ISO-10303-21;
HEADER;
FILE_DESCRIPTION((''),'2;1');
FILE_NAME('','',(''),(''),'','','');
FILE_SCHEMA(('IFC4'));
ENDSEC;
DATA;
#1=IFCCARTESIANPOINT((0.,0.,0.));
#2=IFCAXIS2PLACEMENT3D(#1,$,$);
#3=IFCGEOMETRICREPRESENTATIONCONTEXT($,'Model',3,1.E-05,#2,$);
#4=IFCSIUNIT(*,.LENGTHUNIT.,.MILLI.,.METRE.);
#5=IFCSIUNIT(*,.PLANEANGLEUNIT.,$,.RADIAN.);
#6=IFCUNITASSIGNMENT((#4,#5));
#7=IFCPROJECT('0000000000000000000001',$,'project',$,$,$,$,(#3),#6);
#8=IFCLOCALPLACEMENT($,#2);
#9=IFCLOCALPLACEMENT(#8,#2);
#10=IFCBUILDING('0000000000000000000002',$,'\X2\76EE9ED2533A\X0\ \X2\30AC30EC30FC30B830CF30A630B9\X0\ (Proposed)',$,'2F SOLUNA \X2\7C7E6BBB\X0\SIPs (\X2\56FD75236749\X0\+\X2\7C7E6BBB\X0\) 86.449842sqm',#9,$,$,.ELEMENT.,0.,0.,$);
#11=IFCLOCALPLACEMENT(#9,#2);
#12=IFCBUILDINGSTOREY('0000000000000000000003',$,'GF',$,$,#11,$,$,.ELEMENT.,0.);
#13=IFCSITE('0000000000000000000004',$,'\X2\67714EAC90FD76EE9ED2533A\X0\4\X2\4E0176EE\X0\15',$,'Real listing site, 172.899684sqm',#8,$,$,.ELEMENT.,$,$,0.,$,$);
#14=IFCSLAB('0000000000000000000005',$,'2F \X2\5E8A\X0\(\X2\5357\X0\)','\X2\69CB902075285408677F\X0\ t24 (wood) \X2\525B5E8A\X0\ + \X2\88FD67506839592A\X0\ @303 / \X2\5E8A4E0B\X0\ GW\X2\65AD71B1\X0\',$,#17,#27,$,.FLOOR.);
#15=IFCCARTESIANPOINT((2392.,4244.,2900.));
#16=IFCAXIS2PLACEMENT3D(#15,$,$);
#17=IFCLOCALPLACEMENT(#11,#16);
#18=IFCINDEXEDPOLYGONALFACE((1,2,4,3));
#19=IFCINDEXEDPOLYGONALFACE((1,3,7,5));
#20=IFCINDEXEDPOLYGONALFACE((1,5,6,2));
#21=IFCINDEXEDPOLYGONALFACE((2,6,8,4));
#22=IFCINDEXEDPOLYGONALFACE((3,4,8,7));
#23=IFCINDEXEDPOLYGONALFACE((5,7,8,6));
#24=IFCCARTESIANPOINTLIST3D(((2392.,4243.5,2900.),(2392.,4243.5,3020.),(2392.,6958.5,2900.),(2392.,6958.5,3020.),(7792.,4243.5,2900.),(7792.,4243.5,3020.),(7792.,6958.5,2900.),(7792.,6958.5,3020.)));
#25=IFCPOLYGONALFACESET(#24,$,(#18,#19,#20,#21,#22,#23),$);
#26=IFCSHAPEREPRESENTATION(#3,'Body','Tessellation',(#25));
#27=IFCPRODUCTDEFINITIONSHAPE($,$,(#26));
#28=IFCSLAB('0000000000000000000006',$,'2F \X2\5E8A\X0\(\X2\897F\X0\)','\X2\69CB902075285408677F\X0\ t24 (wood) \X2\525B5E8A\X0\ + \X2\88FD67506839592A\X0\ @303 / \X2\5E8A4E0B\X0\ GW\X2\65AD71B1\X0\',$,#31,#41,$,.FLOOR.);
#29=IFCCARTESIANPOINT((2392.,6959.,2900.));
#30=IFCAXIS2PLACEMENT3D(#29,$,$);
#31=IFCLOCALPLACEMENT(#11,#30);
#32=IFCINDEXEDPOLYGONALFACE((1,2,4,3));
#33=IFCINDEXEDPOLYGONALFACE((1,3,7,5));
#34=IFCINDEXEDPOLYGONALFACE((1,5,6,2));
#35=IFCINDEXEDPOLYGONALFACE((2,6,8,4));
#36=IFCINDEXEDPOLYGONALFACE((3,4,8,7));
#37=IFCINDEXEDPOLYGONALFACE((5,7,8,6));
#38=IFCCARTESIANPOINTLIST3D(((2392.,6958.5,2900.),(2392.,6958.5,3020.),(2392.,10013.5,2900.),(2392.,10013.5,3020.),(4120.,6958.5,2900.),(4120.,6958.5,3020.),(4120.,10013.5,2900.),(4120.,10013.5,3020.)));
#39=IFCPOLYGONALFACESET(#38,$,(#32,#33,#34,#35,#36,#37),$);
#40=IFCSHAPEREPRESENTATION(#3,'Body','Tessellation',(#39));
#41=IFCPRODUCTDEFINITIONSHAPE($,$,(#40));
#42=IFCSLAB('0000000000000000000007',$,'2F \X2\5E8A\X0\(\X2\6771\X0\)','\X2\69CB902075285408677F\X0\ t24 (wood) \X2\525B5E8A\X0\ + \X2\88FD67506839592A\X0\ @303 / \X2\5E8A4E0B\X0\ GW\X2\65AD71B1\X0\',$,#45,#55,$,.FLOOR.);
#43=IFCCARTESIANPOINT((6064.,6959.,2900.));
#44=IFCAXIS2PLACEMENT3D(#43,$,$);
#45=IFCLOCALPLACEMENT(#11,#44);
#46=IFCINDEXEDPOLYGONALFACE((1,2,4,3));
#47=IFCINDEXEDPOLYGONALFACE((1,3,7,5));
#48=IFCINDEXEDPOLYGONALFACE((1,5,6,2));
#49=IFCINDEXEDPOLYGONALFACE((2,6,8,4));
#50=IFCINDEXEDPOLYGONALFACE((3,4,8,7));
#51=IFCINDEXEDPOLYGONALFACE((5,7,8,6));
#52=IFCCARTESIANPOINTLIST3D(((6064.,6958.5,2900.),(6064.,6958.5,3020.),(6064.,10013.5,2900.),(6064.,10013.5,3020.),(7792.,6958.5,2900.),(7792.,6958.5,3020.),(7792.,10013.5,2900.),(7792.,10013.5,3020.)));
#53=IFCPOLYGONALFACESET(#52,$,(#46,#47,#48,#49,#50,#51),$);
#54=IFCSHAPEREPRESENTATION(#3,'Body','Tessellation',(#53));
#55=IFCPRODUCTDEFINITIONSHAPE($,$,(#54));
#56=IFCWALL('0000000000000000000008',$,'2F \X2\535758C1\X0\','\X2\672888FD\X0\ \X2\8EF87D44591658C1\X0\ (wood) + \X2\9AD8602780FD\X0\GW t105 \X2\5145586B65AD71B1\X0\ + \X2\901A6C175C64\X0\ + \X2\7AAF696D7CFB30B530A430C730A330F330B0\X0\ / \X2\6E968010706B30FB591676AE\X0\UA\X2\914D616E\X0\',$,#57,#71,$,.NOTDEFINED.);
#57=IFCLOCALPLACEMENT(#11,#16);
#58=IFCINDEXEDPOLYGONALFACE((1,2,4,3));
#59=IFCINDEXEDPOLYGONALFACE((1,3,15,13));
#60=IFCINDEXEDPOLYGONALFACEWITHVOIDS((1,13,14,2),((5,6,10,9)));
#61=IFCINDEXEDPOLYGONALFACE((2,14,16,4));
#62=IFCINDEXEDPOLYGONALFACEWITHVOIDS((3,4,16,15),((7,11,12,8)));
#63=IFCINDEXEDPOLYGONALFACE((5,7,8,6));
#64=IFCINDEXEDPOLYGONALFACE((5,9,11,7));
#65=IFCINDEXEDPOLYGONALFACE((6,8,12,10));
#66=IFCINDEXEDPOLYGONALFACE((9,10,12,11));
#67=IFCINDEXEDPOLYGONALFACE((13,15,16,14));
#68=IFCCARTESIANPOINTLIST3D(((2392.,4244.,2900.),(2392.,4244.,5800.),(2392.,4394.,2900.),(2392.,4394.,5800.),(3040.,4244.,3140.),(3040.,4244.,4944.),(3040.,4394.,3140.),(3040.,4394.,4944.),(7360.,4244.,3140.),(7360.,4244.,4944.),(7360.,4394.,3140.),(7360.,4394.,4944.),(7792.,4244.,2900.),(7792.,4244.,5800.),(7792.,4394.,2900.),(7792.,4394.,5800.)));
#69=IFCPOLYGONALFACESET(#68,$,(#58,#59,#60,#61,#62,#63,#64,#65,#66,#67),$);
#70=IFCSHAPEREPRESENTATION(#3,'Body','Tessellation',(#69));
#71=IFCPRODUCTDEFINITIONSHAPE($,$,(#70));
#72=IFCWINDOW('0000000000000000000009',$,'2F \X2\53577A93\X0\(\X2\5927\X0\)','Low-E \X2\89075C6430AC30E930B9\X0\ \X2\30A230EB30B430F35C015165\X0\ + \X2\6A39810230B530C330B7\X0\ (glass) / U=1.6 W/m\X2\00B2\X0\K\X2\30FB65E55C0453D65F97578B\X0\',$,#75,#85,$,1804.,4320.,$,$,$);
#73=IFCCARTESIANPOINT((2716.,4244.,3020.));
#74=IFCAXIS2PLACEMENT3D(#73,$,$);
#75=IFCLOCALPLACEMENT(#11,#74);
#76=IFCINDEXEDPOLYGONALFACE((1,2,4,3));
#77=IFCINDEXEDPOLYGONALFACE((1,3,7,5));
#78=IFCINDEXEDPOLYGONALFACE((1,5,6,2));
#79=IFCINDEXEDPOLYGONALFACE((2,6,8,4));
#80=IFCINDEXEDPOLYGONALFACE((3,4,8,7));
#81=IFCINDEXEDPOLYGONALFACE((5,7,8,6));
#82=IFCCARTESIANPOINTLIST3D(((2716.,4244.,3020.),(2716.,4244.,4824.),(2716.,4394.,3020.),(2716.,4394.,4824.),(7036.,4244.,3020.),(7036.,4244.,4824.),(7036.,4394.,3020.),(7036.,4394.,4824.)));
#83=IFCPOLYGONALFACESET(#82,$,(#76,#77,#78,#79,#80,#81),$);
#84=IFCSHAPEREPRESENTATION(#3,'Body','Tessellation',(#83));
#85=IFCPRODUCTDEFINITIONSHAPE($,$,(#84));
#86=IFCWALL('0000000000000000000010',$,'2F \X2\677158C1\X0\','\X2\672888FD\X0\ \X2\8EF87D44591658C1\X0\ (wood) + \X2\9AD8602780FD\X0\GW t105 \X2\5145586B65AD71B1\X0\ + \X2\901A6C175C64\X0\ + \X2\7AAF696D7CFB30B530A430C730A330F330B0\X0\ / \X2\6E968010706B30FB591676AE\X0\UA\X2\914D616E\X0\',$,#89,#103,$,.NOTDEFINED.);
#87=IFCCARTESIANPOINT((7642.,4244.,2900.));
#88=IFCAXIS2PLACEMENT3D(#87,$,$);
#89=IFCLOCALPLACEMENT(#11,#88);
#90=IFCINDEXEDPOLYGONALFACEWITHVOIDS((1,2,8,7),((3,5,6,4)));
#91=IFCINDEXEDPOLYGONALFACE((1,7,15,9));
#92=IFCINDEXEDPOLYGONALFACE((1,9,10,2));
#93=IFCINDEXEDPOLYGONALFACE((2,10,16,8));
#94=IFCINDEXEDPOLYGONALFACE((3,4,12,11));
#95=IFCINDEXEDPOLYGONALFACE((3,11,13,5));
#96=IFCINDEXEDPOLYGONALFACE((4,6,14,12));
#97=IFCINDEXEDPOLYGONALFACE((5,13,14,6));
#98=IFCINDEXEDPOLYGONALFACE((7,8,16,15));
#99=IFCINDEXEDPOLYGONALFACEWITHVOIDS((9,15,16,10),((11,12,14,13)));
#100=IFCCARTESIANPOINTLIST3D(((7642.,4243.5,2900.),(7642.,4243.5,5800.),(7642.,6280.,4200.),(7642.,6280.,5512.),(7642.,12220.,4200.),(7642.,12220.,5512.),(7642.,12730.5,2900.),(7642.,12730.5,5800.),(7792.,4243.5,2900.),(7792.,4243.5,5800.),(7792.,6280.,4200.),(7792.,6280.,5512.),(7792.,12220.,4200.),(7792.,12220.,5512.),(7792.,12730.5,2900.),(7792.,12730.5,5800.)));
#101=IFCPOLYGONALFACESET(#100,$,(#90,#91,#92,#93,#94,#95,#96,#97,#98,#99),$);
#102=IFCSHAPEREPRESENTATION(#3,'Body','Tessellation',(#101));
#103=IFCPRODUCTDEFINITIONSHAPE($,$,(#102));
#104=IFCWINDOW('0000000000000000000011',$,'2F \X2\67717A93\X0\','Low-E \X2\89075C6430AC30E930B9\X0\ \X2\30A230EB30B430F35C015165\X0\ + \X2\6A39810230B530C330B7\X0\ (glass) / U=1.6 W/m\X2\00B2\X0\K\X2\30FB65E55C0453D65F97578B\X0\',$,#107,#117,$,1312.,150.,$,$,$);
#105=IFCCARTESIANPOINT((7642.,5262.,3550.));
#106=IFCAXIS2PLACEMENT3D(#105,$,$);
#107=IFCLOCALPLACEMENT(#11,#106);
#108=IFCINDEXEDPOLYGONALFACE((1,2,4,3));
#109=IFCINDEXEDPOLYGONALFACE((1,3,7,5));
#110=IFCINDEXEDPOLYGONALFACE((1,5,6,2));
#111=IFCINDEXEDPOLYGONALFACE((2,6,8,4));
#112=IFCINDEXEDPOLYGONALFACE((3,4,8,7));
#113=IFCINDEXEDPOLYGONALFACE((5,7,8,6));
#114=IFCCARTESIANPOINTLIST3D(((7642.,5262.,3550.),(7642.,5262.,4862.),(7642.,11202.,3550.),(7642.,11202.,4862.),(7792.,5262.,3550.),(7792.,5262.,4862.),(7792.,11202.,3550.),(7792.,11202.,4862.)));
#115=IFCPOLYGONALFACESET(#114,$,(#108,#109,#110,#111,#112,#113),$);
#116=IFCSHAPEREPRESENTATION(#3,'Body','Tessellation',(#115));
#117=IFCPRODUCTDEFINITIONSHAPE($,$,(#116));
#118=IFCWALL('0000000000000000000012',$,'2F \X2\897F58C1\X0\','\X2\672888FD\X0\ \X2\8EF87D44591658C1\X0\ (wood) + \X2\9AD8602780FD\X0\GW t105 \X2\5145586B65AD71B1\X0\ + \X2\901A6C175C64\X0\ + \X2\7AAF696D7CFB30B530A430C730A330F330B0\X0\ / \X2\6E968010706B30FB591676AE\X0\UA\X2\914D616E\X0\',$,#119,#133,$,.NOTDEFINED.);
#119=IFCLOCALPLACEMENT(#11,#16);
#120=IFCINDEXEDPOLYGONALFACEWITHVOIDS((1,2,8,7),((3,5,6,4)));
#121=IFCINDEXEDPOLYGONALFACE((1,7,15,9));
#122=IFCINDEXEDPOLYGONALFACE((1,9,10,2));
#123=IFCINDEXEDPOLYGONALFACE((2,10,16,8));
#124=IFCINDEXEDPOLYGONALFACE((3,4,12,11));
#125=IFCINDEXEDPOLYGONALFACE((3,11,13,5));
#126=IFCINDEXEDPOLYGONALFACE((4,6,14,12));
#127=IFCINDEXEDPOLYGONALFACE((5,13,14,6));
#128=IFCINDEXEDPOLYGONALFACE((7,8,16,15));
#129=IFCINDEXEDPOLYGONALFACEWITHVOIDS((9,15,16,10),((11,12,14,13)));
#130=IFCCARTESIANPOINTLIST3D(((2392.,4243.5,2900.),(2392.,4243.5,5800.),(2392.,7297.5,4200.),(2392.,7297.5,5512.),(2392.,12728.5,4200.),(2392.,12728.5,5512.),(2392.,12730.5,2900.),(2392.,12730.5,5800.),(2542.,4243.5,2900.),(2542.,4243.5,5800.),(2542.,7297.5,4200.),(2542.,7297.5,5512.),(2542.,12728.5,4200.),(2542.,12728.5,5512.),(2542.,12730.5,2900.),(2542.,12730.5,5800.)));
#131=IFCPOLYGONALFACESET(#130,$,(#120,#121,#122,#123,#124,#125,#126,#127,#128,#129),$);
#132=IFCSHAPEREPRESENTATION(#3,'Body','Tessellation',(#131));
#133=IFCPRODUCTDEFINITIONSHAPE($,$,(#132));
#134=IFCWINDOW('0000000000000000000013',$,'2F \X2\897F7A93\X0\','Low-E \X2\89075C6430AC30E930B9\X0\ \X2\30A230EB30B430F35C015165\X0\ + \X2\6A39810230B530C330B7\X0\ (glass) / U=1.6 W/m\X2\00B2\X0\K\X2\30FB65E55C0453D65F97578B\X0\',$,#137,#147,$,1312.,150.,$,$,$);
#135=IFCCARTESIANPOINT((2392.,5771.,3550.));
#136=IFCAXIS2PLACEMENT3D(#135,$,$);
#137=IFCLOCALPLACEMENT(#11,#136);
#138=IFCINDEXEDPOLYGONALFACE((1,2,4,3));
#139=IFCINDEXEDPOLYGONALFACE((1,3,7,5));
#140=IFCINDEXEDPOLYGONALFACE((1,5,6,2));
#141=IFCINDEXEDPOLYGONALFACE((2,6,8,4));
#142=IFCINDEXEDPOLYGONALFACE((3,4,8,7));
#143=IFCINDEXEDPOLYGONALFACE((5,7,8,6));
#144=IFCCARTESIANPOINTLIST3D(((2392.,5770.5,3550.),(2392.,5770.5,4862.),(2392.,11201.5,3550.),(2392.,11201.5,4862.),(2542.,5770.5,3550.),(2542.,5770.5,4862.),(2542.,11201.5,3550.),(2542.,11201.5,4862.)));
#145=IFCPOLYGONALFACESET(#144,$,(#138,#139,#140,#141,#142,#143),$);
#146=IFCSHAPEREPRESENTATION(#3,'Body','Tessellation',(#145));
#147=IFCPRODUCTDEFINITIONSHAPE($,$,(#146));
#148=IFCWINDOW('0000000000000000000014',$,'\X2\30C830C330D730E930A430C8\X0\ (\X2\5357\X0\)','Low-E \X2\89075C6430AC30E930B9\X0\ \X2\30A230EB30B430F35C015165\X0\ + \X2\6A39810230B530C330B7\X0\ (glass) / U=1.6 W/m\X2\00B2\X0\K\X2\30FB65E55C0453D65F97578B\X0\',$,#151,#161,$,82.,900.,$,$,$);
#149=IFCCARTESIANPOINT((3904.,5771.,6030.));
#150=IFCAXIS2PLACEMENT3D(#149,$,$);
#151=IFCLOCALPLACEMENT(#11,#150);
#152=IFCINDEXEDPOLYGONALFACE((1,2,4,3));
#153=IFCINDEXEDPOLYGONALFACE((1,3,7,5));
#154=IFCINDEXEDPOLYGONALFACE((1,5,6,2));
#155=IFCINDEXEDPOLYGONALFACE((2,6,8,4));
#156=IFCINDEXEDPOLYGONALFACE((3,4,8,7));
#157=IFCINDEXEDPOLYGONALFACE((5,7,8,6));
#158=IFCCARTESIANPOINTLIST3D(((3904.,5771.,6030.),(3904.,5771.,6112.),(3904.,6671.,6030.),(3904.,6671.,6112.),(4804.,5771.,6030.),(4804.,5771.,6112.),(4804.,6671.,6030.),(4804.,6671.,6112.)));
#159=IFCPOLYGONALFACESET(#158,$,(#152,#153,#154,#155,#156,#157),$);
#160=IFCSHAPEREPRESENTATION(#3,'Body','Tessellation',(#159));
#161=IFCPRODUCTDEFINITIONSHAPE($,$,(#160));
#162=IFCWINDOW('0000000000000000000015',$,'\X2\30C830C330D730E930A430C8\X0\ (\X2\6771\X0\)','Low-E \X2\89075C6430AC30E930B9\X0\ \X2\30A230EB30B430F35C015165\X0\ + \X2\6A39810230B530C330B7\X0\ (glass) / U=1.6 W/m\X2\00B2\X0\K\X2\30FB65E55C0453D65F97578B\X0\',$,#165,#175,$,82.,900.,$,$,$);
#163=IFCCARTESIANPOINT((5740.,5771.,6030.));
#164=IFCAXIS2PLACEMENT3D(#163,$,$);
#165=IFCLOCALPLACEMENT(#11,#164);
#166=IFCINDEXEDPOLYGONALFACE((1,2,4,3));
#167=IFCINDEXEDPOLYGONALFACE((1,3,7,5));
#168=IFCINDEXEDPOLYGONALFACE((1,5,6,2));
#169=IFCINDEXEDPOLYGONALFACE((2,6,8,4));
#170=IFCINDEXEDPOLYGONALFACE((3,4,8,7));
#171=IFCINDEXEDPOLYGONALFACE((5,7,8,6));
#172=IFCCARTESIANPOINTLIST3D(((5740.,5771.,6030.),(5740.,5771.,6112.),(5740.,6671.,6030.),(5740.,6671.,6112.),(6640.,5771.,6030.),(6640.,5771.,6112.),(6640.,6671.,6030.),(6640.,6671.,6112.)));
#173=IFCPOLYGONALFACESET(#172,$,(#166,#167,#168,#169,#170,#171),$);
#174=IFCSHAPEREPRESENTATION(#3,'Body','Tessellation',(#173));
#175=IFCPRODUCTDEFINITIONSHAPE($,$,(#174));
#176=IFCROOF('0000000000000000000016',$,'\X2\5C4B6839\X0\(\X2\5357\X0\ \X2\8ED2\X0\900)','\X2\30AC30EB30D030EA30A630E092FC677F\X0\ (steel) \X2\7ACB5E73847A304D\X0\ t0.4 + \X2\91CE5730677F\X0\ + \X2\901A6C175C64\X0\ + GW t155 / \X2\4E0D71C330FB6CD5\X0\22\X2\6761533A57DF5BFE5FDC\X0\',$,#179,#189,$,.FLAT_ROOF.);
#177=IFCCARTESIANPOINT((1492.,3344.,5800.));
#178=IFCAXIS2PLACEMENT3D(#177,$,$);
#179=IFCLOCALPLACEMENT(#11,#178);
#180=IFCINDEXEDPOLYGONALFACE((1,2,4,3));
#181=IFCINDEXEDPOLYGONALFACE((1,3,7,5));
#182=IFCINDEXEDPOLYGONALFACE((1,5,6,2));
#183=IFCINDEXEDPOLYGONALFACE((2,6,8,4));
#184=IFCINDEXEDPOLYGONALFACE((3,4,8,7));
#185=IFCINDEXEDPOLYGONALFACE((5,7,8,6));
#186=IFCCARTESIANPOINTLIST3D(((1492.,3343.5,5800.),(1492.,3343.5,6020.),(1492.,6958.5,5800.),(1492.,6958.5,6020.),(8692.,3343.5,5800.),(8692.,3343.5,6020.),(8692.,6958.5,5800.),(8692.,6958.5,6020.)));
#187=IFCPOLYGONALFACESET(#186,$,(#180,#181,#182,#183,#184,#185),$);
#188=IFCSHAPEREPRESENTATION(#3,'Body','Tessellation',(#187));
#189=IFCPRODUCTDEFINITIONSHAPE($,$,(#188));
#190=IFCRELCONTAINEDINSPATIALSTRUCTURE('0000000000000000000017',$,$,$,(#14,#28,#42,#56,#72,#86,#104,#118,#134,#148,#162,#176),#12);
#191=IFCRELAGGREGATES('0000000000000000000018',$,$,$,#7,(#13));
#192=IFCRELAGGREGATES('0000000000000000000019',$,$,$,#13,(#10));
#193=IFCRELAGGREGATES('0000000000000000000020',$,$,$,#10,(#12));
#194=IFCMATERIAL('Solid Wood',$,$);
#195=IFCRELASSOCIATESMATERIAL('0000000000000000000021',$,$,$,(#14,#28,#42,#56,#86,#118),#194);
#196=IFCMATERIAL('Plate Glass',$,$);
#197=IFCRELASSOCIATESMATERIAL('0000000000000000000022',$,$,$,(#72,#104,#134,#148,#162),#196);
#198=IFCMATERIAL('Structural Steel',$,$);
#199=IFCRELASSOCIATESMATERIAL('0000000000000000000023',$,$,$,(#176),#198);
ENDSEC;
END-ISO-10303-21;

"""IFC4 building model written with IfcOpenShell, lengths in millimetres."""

from ifc_helpers import new_model, si_unit, frame, frame_2d, origin, place, context, project, spatial, rectangle, extrude, material, element, fill, save


model = new_model("IFC4")

# Units and contexts
model_context = context("Model", 3, precision=1e-05, world=origin())
ifc_project = project(units=[si_unit("LENGTHUNIT", "METRE", prefix="MILLI"), si_unit("PLANEANGLEUNIT", "RADIAN")], contexts=[model_context])

# Site, building, storey
site_placement = place(None, origin())
site = spatial("IfcSite", under=ifc_project, at=site_placement, Name="東京都目黒区4丁目15", ObjectType="Real listing site, 172.899684sqm", CompositionType="ELEMENT", RefElevation=0.0)
building_placement = place(site_placement, origin())
building = spatial("IfcBuilding", under=site, at=building_placement, Name="目黒区 ガレージハウス (Proposed)", ObjectType="2F SOLUNA 籾殻SIPs (国産杉+籾殻) 86.449842sqm", CompositionType="ELEMENT", ElevationOfRefHeight=0.0, ElevationOfTerrain=0.0)
storey_placement = place(building_placement, origin())
storey = spatial("IfcBuildingStorey", under=building, at=storey_placement, Name="GF", CompositionType="ELEMENT", Elevation=0.0)

# Slabs
ifc_material_1 = material(Name="Solid Wood")
slab_1_placement = place(storey_placement, frame((2392.0, 4244.0, 2900.0)))
element("IfcSlab", 1, at=slab_1_placement, inside=storey, material=ifc_material_1, Name="2F 床(南)", Description="構造用合板 t24 (wood) 剛床 + 製材根太 @303 / 床下 GW断熱", PredefinedType="FLOOR", context=model_context, shape_type="SweptSolid", body=[
    extrude(rectangle(XDim=5400.0, YDim=2715.0, at=frame_2d((2700.0, 1357.0))), frame((2392.0, 4244.0, 2900.0)), (0.0, 0.0, 1.0), 120.0),
])
slab_2_placement = place(storey_placement, frame((2392.0, 6959.0, 2900.0)))
element("IfcSlab", 2, at=slab_2_placement, inside=storey, material=ifc_material_1, Name="2F 床(西)", Description="構造用合板 t24 (wood) 剛床 + 製材根太 @303 / 床下 GW断熱", PredefinedType="FLOOR", context=model_context, shape_type="SweptSolid", body=[
    extrude(rectangle(XDim=1728.0, YDim=3055.0, at=frame_2d((864.0, 1527.0))), frame((2392.0, 6959.0, 2900.0)), (0.0, 0.0, 1.0), 120.0),
])
slab_3_placement = place(storey_placement, frame((6064.0, 6959.0, 2900.0)))
element("IfcSlab", 3, at=slab_3_placement, inside=storey, material=ifc_material_1, Name="2F 床(東)", Description="構造用合板 t24 (wood) 剛床 + 製材根太 @303 / 床下 GW断熱", PredefinedType="FLOOR", context=model_context, shape_type="SweptSolid", body=[
    extrude(rectangle(XDim=1728.0, YDim=3055.0, at=frame_2d((864.0, 1527.0))), frame((6064.0, 6959.0, 2900.0)), (0.0, 0.0, 1.0), 120.0),
])

# Walls, openings, windows
wall_1_placement = place(storey_placement, frame((2392.0, 4244.0, 2900.0)))
wall_1 = element("IfcWall", 4, at=wall_1_placement, inside=storey, material=ifc_material_1, Name="2F 南壁", Description="木製 軸組外壁 (wood) + 高性能GW t105 充填断熱 + 通気層 + 窯業系サイディング / 準耐火・外皮UA配慮", PredefinedType="NOTDEFINED", context=model_context, shape_type="SweptSolid", body=[
    extrude(rectangle(XDim=5400.0, YDim=150.0, at=frame_2d((2700.0, 75.0))), frame((2392.0, 4244.0, 2900.0)), (0.0, 0.0, 1.0), 2900.0),
])
opening_1_placement = place(storey_placement, frame((2716.0, 4244.0, 3020.0)))
opening_1 = element("IfcOpeningElement", 5, at=opening_1_placement, cuts=wall_1, PredefinedType="NOTDEFINED", context=model_context, shape_type="SweptSolid", body=[
    extrude(rectangle(XDim=4320.0, YDim=150.0, at=frame_2d((2160.0, 75.0))), frame((2716.0, 4244.0, 3020.0)), (0.0, 0.0, 1.0), 1804.0),
])
ifc_material_2 = material(Name="Plate Glass")
window_1_placement = place(storey_placement, frame((2716.0, 4244.0, 3020.0)))
window_1 = element("IfcWindow", 6, at=window_1_placement, inside=storey, material=ifc_material_2, Name="2F 南窓(大)", Description="Low-E 複層ガラス アルゴン封入 + 樹脂サッシ (glass) / U=1.6 W/m²K・日射取得型", OverallHeight=1804.0, OverallWidth=4320.0, context=model_context, shape_type="SweptSolid", body=[
    extrude(rectangle(XDim=4320.0, YDim=150.0, at=frame_2d((2160.0, 75.0))), frame((2716.0, 4244.0, 3020.0)), (0.0, 0.0, 1.0), 1804.0),
])
fill(opening_1, window_1)
wall_2_placement = place(storey_placement, frame((7642.0, 4244.0, 2900.0)))
wall_2 = element("IfcWall", 7, at=wall_2_placement, inside=storey, material=ifc_material_1, Name="2F 東壁", Description="木製 軸組外壁 (wood) + 高性能GW t105 充填断熱 + 通気層 + 窯業系サイディング / 準耐火・外皮UA配慮", PredefinedType="NOTDEFINED", context=model_context, shape_type="SweptSolid", body=[
    extrude(rectangle(XDim=150.0, YDim=8487.0, at=frame_2d((75.0, 4243.0))), frame((7642.0, 4244.0, 2900.0)), (0.0, 0.0, 1.0), 2900.0),
])
opening_2_placement = place(storey_placement, frame((7642.0, 5262.0, 3550.0)))
opening_2 = element("IfcOpeningElement", 8, at=opening_2_placement, cuts=wall_2, PredefinedType="NOTDEFINED", context=model_context, shape_type="SweptSolid", body=[
    extrude(rectangle(XDim=150.0, YDim=5940.0, at=frame_2d((75.0, 2970.0))), frame((7642.0, 5262.0, 3550.0)), (0.0, 0.0, 1.0), 1312.0),
])
window_2_placement = place(storey_placement, frame((7642.0, 5262.0, 3550.0)))
window_2 = element("IfcWindow", 9, at=window_2_placement, inside=storey, material=ifc_material_2, Name="2F 東窓", Description="Low-E 複層ガラス アルゴン封入 + 樹脂サッシ (glass) / U=1.6 W/m²K・日射取得型", OverallHeight=1312.0, OverallWidth=150.0, context=model_context, shape_type="SweptSolid", body=[
    extrude(rectangle(XDim=150.0, YDim=5940.0, at=frame_2d((75.0, 2970.0))), frame((7642.0, 5262.0, 3550.0)), (0.0, 0.0, 1.0), 1312.0),
])
fill(opening_2, window_2)
wall_3_placement = place(storey_placement, frame((2392.0, 4244.0, 2900.0)))
wall_3 = element("IfcWall", 10, at=wall_3_placement, inside=storey, material=ifc_material_1, Name="2F 西壁", Description="木製 軸組外壁 (wood) + 高性能GW t105 充填断熱 + 通気層 + 窯業系サイディング / 準耐火・外皮UA配慮", PredefinedType="NOTDEFINED", context=model_context, shape_type="SweptSolid", body=[
    extrude(rectangle(XDim=150.0, YDim=8487.0, at=frame_2d((75.0, 4243.0))), frame((2392.0, 4244.0, 2900.0)), (0.0, 0.0, 1.0), 2900.0),
])
opening_3_placement = place(storey_placement, frame((2392.0, 5771.0, 3550.0)))
opening_3 = element("IfcOpeningElement", 11, at=opening_3_placement, cuts=wall_3, PredefinedType="NOTDEFINED", context=model_context, shape_type="SweptSolid", body=[
    extrude(rectangle(XDim=150.0, YDim=5431.0, at=frame_2d((75.0, 2715.0))), frame((2392.0, 5771.0, 3550.0)), (0.0, 0.0, 1.0), 1312.0),
])
window_3_placement = place(storey_placement, frame((2392.0, 5771.0, 3550.0)))
window_3 = element("IfcWindow", 12, at=window_3_placement, inside=storey, material=ifc_material_2, Name="2F 西窓", Description="Low-E 複層ガラス アルゴン封入 + 樹脂サッシ (glass) / U=1.6 W/m²K・日射取得型", OverallHeight=1312.0, OverallWidth=150.0, context=model_context, shape_type="SweptSolid", body=[
    extrude(rectangle(XDim=150.0, YDim=5431.0, at=frame_2d((75.0, 2715.0))), frame((2392.0, 5771.0, 3550.0)), (0.0, 0.0, 1.0), 1312.0),
])
fill(opening_3, window_3)

# Windows
window_4_placement = place(storey_placement, frame((3904.0, 5771.0, 6030.0)))
element("IfcWindow", 13, at=window_4_placement, inside=storey, material=ifc_material_2, Name="トップライト (南)", Description="Low-E 複層ガラス アルゴン封入 + 樹脂サッシ (glass) / U=1.6 W/m²K・日射取得型", OverallHeight=82.0, OverallWidth=900.0, context=model_context, shape_type="SweptSolid", body=[
    extrude(rectangle(XDim=900.0, YDim=900.0, at=frame_2d((450.0, 450.0))), frame((3904.0, 5771.0, 6030.0)), (0.0, 0.0, 1.0), 82.0),
])
window_5_placement = place(storey_placement, frame((5740.0, 5771.0, 6030.0)))
element("IfcWindow", 14, at=window_5_placement, inside=storey, material=ifc_material_2, Name="トップライト (東)", Description="Low-E 複層ガラス アルゴン封入 + 樹脂サッシ (glass) / U=1.6 W/m²K・日射取得型", OverallHeight=82.0, OverallWidth=900.0, context=model_context, shape_type="SweptSolid", body=[
    extrude(rectangle(XDim=900.0, YDim=900.0, at=frame_2d((450.0, 450.0))), frame((5740.0, 5771.0, 6030.0)), (0.0, 0.0, 1.0), 82.0),
])

# Roof
ifc_material_3 = material(Name="Structural Steel")
roof_1_placement = place(storey_placement, frame((1492.0, 3344.0, 5800.0)))
element("IfcRoof", 15, at=roof_1_placement, inside=storey, material=ifc_material_3, Name="屋根(南 軒900)", Description="ガルバリウム鋼板 (steel) 立平葺き t0.4 + 野地板 + 通気層 + GW t155 / 不燃・法22条区域対応", PredefinedType="FLAT_ROOF", context=model_context, shape_type="SweptSolid", body=[
    extrude(rectangle(XDim=7200.0, YDim=3615.0, at=frame_2d((3600.0, 1807.0))), frame((1492.0, 3344.0, 5800.0)), (0.0, 0.0, 1.0), 220.0),
])

save(model, "model.ifc")
